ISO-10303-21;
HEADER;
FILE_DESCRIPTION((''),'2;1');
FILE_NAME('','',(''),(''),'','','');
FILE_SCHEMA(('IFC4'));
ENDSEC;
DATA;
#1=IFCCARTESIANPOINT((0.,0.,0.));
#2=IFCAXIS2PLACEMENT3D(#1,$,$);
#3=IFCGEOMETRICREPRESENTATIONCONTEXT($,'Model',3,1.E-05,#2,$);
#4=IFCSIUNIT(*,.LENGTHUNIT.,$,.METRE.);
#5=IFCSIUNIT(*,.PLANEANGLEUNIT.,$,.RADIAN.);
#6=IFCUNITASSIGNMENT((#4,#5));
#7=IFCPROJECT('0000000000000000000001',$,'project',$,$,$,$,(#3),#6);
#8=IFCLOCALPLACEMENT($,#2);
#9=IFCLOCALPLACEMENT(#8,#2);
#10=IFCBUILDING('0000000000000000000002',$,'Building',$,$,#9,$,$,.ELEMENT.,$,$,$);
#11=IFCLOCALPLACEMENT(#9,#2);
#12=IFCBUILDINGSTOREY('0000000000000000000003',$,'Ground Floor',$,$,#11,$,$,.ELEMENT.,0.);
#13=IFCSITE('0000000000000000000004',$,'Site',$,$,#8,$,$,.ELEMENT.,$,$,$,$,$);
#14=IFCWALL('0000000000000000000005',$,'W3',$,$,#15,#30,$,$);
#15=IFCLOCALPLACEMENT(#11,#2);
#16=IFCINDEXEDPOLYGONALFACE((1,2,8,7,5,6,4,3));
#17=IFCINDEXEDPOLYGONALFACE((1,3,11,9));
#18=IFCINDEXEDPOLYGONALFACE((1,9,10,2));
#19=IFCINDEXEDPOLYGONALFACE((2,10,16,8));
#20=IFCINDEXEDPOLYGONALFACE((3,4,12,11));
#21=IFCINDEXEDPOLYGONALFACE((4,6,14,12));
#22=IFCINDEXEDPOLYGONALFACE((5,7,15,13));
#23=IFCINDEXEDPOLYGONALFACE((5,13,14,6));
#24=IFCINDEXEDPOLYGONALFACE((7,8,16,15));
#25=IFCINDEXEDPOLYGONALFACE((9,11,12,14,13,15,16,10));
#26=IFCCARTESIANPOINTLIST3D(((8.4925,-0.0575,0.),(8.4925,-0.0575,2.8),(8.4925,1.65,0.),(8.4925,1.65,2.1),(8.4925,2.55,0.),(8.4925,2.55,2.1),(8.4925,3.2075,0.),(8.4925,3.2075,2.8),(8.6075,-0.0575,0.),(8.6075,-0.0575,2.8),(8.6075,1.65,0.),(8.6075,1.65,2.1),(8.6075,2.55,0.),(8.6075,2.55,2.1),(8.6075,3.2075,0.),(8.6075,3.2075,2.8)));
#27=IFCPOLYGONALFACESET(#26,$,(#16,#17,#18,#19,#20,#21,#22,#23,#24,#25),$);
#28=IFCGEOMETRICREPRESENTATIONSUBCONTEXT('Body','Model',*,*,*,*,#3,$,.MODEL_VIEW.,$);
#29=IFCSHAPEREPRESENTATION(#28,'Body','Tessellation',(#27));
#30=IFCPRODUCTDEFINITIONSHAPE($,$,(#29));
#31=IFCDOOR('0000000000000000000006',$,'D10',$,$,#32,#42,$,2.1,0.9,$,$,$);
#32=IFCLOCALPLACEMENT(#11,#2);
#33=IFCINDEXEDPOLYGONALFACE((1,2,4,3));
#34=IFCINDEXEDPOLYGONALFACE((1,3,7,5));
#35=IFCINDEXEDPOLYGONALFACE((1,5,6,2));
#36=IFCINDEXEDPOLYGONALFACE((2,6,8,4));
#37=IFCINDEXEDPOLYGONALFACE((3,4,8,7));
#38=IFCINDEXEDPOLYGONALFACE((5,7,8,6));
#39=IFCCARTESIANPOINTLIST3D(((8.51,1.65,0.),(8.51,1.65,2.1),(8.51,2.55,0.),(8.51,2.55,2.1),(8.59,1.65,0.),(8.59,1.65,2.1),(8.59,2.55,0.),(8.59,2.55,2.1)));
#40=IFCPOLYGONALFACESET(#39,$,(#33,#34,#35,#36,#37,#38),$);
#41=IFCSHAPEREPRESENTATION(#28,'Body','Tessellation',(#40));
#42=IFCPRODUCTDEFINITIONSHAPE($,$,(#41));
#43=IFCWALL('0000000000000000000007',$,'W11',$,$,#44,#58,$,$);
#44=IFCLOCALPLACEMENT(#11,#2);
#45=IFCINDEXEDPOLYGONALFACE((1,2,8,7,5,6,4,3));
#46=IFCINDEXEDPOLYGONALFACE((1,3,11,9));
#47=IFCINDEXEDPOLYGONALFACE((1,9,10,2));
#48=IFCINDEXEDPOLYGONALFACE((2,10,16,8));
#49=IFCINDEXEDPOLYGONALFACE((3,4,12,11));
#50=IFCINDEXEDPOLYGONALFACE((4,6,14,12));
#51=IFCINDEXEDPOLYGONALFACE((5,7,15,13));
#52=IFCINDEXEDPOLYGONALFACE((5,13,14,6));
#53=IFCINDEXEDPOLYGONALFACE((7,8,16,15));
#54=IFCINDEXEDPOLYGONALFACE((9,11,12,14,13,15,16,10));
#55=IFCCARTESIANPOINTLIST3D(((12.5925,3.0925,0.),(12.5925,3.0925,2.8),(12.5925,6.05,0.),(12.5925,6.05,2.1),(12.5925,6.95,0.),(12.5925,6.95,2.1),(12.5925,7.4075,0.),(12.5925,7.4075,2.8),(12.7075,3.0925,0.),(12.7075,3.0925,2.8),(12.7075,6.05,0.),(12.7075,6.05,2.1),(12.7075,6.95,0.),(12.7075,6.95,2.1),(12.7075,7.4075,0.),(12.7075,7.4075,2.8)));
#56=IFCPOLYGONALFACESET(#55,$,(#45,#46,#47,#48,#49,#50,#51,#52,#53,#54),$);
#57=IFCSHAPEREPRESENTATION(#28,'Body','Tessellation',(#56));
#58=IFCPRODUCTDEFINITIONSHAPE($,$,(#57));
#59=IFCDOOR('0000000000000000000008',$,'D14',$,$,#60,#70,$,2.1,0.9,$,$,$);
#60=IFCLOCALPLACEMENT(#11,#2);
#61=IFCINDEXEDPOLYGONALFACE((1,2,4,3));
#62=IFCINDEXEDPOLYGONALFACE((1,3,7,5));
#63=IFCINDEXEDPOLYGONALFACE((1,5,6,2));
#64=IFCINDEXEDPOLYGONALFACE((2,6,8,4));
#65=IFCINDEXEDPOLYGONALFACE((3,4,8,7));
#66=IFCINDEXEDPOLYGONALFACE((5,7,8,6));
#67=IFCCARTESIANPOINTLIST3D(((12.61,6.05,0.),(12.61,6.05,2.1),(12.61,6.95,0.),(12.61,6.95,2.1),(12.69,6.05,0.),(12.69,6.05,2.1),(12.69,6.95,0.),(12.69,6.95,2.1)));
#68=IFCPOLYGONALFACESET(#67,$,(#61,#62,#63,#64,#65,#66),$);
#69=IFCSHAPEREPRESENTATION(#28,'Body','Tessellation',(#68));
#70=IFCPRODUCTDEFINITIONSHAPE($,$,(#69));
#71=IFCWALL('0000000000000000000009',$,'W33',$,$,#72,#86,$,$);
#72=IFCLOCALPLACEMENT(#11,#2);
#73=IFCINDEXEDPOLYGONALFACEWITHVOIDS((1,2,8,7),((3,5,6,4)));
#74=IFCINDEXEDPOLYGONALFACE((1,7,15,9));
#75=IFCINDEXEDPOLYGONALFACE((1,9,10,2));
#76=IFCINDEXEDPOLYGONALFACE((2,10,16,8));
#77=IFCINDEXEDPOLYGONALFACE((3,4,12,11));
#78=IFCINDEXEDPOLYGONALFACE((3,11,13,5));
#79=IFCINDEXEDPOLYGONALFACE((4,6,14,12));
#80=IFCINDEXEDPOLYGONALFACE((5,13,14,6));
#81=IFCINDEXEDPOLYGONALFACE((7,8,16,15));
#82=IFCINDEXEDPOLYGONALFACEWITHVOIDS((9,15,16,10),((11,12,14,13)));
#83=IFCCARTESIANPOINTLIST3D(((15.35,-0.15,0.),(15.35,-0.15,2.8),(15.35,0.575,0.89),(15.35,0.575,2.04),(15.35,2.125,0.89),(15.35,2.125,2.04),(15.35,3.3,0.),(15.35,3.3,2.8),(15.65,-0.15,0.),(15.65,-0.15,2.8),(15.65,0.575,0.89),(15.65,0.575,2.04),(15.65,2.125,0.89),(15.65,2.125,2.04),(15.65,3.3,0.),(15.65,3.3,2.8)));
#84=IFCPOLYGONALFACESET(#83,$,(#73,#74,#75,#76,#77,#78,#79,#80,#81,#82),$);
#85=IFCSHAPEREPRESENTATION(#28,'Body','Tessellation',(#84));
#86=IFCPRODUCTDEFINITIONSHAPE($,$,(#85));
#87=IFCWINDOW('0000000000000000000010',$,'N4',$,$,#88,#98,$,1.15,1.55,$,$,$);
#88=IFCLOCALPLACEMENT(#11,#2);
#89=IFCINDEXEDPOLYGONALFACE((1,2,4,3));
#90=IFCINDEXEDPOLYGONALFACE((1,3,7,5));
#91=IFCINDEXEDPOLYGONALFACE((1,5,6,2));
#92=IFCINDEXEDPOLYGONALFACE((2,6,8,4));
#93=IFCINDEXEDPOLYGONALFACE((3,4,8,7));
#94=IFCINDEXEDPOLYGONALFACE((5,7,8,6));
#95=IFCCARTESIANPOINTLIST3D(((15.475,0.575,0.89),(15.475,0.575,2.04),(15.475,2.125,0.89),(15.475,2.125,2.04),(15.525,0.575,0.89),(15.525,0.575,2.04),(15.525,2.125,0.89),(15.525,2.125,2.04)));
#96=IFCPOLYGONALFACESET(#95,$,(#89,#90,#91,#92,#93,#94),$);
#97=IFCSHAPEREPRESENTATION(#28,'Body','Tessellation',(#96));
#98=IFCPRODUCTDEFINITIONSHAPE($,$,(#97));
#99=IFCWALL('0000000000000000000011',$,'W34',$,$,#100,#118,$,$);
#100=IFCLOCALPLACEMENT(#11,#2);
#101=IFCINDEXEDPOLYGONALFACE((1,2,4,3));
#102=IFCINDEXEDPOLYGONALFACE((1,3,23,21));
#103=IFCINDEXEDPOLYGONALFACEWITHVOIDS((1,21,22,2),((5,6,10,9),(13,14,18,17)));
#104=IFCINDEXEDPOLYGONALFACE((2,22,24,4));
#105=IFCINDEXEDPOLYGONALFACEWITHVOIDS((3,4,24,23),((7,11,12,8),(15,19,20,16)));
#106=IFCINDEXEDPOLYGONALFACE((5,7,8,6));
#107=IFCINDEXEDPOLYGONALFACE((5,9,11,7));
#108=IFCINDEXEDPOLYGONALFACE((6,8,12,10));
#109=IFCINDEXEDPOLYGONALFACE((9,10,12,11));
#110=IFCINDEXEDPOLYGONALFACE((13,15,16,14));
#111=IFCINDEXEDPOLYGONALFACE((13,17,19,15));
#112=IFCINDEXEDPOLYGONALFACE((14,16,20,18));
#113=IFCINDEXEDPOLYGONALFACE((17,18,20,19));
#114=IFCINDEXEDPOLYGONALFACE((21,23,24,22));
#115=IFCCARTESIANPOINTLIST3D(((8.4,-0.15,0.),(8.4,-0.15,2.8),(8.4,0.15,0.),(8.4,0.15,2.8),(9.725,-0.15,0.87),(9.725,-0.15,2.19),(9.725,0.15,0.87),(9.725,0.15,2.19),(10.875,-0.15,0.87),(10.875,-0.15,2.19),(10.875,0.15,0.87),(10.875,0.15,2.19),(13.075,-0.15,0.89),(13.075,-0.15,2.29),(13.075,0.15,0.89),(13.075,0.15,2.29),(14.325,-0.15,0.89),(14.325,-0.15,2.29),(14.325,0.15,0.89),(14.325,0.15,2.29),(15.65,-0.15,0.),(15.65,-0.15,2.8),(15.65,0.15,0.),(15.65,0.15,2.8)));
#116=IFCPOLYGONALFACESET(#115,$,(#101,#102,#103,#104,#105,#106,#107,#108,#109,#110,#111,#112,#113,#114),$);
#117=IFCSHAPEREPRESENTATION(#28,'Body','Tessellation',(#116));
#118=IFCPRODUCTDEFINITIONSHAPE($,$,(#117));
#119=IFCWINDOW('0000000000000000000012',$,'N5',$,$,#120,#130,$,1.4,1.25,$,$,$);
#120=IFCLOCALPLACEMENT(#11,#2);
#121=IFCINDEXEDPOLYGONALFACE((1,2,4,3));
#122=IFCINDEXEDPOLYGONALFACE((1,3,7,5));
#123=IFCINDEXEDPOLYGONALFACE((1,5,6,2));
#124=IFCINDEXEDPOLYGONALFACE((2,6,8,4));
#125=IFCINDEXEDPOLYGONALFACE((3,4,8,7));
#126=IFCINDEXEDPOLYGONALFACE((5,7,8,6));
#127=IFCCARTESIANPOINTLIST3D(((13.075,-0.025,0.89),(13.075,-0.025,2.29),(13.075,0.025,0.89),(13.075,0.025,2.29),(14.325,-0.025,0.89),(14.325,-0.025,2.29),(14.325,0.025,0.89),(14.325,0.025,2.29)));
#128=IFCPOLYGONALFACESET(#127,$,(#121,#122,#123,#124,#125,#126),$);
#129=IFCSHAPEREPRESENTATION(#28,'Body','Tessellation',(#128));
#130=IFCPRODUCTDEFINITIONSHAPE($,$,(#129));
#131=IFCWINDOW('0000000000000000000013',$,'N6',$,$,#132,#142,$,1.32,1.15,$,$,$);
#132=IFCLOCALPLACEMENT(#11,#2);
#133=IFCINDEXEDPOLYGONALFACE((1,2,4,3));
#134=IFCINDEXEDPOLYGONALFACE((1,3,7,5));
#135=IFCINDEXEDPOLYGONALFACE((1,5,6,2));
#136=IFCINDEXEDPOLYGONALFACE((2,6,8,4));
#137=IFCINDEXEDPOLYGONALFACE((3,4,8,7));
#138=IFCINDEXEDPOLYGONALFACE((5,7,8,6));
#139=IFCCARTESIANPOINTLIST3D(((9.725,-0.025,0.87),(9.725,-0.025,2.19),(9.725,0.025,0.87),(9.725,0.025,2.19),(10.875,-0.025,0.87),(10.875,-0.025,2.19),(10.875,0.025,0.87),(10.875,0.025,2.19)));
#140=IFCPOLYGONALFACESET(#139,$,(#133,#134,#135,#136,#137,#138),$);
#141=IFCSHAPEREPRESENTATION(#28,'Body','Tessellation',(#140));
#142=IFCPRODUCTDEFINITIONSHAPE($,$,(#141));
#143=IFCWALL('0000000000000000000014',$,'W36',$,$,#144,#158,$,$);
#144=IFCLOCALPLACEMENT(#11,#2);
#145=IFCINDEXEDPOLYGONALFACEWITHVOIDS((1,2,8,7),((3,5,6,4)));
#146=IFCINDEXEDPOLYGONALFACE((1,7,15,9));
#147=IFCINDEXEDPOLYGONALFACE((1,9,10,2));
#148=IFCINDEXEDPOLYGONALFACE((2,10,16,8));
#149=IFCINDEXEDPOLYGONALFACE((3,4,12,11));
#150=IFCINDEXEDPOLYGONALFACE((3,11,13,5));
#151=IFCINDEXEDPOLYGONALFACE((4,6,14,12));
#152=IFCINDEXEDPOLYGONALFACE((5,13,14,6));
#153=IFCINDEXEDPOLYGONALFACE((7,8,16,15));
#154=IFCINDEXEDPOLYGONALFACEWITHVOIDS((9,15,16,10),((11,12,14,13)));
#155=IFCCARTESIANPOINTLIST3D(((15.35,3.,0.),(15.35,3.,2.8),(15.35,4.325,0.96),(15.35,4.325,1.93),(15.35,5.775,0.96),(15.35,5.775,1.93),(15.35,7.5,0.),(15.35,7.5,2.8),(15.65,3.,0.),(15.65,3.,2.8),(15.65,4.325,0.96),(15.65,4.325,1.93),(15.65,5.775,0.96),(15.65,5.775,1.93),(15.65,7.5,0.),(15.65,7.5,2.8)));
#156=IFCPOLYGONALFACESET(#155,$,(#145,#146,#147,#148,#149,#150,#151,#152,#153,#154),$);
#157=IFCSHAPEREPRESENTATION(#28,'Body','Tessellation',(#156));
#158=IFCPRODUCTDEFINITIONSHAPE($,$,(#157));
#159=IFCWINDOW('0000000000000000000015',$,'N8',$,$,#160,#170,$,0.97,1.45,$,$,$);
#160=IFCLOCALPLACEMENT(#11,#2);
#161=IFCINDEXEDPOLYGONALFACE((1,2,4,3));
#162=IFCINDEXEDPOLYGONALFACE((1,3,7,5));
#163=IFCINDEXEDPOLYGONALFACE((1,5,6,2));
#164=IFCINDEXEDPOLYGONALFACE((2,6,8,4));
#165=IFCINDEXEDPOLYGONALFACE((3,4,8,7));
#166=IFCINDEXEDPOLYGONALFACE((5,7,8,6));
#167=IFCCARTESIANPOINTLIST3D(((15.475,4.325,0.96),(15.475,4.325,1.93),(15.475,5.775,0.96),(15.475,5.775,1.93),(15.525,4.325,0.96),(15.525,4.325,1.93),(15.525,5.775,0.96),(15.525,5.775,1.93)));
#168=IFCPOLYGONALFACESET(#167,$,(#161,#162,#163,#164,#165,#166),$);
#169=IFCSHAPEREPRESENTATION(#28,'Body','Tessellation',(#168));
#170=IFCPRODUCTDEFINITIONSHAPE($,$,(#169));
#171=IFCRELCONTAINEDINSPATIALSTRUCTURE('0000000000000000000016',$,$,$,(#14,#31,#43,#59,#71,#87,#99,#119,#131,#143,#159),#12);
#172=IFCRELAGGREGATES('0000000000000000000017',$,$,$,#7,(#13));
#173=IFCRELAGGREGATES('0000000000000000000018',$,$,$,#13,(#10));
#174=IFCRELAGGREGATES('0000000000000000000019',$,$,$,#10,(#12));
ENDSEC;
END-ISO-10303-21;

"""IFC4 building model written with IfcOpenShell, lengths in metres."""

from ifc_helpers import new_model, si_unit, frame, frame_2d, origin, origin_2d, place, context, subcontext, project, spatial, rectangle, extrude, element, fill, save


model = new_model("IFC4")

# Units and contexts
model_context = context("Model", 3, precision=1e-05, world=origin())
body_context = subcontext(model_context, "Body", "Model", "MODEL_VIEW")
ifc_project = project(units=[si_unit("LENGTHUNIT", "METRE"), si_unit("PLANEANGLEUNIT", "RADIAN")], contexts=[model_context])

# Site, building, storey
site_placement = place(None, origin())
site = spatial("IfcSite", under=ifc_project, at=site_placement, Name="Site", CompositionType="ELEMENT")
building_placement = place(site_placement, origin())
building = spatial("IfcBuilding", under=site, at=building_placement, Name="Building", CompositionType="ELEMENT")
storey_placement = place(building_placement, origin())
storey = spatial("IfcBuildingStorey", under=building, at=storey_placement, Name="Ground Floor", CompositionType="ELEMENT", Elevation=0.0)

# Wall, opening, door
wall_1_placement = place(storey_placement, frame((8.55, 0.0, 0.0), x_axis=(0.0, 1.0, 0.0)))
wall_1 = element("IfcWall", 1, at=wall_1_placement, inside=storey, Name="W3", context=body_context, shape_type="SweptSolid", body=[
    extrude(rectangle(XDim=3.265, YDim=0.115, at=frame_2d((1.575, 0.0))), origin(), (0.0, 0.0, 1.0), 2.8),
])
opening_1_placement = place(wall_1_placement, frame((2.1, 0.0, 0.0)))
opening_1 = element("IfcOpeningElement", 2, at=opening_1_placement, cuts=wall_1, context=body_context, shape_type="SweptSolid", body=[
    extrude(rectangle(XDim=0.9, YDim=0.215, at=origin_2d()), origin(), (0.0, 0.0, 1.0), 2.1),
])
door_1_placement = place(opening_1_placement, origin())
door_1 = element("IfcDoor", 3, at=door_1_placement, inside=storey, Name="D10", OverallHeight=2.1, OverallWidth=0.9, context=body_context, shape_type="SweptSolid", body=[
    extrude(rectangle(XDim=0.9, YDim=0.08, at=origin_2d()), origin(), (0.0, 0.0, 1.0), 2.1),
])
fill(opening_1, door_1)

# Wall, opening, door
wall_2_placement = place(storey_placement, frame((12.65, 3.15, 0.0), x_axis=(0.0, 1.0, 0.0)))
wall_2 = element("IfcWall", 4, at=wall_2_placement, inside=storey, Name="W11", context=body_context, shape_type="SweptSolid", body=[
    extrude(rectangle(XDim=4.315, YDim=0.115, at=frame_2d((2.1, 0.0))), origin(), (0.0, 0.0, 1.0), 2.8),
])
opening_2_placement = place(wall_2_placement, frame((3.35, 0.0, 0.0)))
opening_2 = element("IfcOpeningElement", 5, at=opening_2_placement, cuts=wall_2, context=body_context, shape_type="SweptSolid", body=[
    extrude(rectangle(XDim=0.9, YDim=0.215, at=origin_2d()), origin(), (0.0, 0.0, 1.0), 2.1),
])
door_2_placement = place(opening_2_placement, origin())
door_2 = element("IfcDoor", 6, at=door_2_placement, inside=storey, Name="D14", OverallHeight=2.1, OverallWidth=0.9, context=body_context, shape_type="SweptSolid", body=[
    extrude(rectangle(XDim=0.9, YDim=0.08, at=origin_2d()), origin(), (0.0, 0.0, 1.0), 2.1),
])
fill(opening_2, door_2)

# Wall, opening, window
wall_3_placement = place(storey_placement, frame((15.5, 0.0, 0.0), x_axis=(0.0, 1.0, 0.0)))
wall_3 = element("IfcWall", 7, at=wall_3_placement, inside=storey, Name="W33", context=body_context, shape_type="SweptSolid", body=[
    extrude(rectangle(XDim=3.45, YDim=0.3, at=frame_2d((1.575, 0.0))), origin(), (0.0, 0.0, 1.0), 2.8),
])
opening_3_placement = place(wall_3_placement, frame((1.35, 0.0, 0.89)))
opening_3 = element("IfcOpeningElement", 8, at=opening_3_placement, cuts=wall_3, context=body_context, shape_type="SweptSolid", body=[
    extrude(rectangle(XDim=1.55, YDim=0.4, at=origin_2d()), origin(), (0.0, 0.0, 1.0), 1.15),
])
window_1_placement = place(opening_3_placement, origin())
window_1 = element("IfcWindow", 9, at=window_1_placement, inside=storey, Name="N4", OverallHeight=1.15, OverallWidth=1.55, context=body_context, shape_type="SweptSolid", body=[
    extrude(rectangle(XDim=1.55, YDim=0.05, at=origin_2d()), origin(), (0.0, 0.0, 1.0), 1.15),
])
fill(opening_3, window_1)

# Wall, openings, windows
wall_4_placement = place(storey_placement, frame((8.55, 0.0, 0.0), x_axis=(1.0, 0.0, 0.0)))
wall_4 = element("IfcWall", 10, at=wall_4_placement, inside=storey, Name="W34", context=body_context, shape_type="SweptSolid", body=[
    extrude(rectangle(XDim=7.25, YDim=0.3, at=frame_2d((3.475, 0.0))), origin(), (0.0, 0.0, 1.0), 2.8),
])
opening_4_placement = place(wall_4_placement, frame((5.15, 0.0, 0.89)))
opening_4 = element("IfcOpeningElement", 11, at=opening_4_placement, cuts=wall_4, context=body_context, shape_type="SweptSolid", body=[
    extrude(rectangle(XDim=1.25, YDim=0.4, at=origin_2d()), origin(), (0.0, 0.0, 1.0), 1.4),
])
opening_5_placement = place(wall_4_placement, frame((1.75, 0.0, 0.87)))
opening_5 = element("IfcOpeningElement", 12, at=opening_5_placement, cuts=wall_4, context=body_context, shape_type="SweptSolid", body=[
    extrude(rectangle(XDim=1.15, YDim=0.4, at=origin_2d()), origin(), (0.0, 0.0, 1.0), 1.32),
])
window_2_placement = place(opening_4_placement, origin())
window_2 = element("IfcWindow", 13, at=window_2_placement, inside=storey, Name="N5", OverallHeight=1.4, OverallWidth=1.25, context=body_context, shape_type="SweptSolid", body=[
    extrude(rectangle(XDim=1.25, YDim=0.05, at=origin_2d()), origin(), (0.0, 0.0, 1.0), 1.4),
])
fill(opening_4, window_2)
window_3_placement = place(opening_5_placement, origin())
window_3 = element("IfcWindow", 14, at=window_3_placement, inside=storey, Name="N6", OverallHeight=1.32, OverallWidth=1.15, context=body_context, shape_type="SweptSolid", body=[
    extrude(rectangle(XDim=1.15, YDim=0.05, at=origin_2d()), origin(), (0.0, 0.0, 1.0), 1.32),
])
fill(opening_5, window_3)

# Wall, opening, window
wall_5_placement = place(storey_placement, frame((15.5, 3.15, 0.0), x_axis=(0.0, 1.0, 0.0)))
wall_5 = element("IfcWall", 15, at=wall_5_placement, inside=storey, Name="W36", context=body_context, shape_type="SweptSolid", body=[
    extrude(rectangle(XDim=4.5, YDim=0.3, at=frame_2d((2.1, 0.0))), origin(), (0.0, 0.0, 1.0), 2.8),
])
opening_6_placement = place(wall_5_placement, frame((1.9, 0.0, 0.96)))
opening_6 = element("IfcOpeningElement", 16, at=opening_6_placement, cuts=wall_5, context=body_context, shape_type="SweptSolid", body=[
    extrude(rectangle(XDim=1.45, YDim=0.4, at=origin_2d()), origin(), (0.0, 0.0, 1.0), 0.97),
])
window_4_placement = place(opening_6_placement, origin())
window_4 = element("IfcWindow", 17, at=window_4_placement, inside=storey, Name="N8", OverallHeight=0.97, OverallWidth=1.45, context=body_context, shape_type="SweptSolid", body=[
    extrude(rectangle(XDim=1.45, YDim=0.05, at=origin_2d()), origin(), (0.0, 0.0, 1.0), 0.97),
])
fill(opening_6, window_4)

save(model, "model.ifc")
